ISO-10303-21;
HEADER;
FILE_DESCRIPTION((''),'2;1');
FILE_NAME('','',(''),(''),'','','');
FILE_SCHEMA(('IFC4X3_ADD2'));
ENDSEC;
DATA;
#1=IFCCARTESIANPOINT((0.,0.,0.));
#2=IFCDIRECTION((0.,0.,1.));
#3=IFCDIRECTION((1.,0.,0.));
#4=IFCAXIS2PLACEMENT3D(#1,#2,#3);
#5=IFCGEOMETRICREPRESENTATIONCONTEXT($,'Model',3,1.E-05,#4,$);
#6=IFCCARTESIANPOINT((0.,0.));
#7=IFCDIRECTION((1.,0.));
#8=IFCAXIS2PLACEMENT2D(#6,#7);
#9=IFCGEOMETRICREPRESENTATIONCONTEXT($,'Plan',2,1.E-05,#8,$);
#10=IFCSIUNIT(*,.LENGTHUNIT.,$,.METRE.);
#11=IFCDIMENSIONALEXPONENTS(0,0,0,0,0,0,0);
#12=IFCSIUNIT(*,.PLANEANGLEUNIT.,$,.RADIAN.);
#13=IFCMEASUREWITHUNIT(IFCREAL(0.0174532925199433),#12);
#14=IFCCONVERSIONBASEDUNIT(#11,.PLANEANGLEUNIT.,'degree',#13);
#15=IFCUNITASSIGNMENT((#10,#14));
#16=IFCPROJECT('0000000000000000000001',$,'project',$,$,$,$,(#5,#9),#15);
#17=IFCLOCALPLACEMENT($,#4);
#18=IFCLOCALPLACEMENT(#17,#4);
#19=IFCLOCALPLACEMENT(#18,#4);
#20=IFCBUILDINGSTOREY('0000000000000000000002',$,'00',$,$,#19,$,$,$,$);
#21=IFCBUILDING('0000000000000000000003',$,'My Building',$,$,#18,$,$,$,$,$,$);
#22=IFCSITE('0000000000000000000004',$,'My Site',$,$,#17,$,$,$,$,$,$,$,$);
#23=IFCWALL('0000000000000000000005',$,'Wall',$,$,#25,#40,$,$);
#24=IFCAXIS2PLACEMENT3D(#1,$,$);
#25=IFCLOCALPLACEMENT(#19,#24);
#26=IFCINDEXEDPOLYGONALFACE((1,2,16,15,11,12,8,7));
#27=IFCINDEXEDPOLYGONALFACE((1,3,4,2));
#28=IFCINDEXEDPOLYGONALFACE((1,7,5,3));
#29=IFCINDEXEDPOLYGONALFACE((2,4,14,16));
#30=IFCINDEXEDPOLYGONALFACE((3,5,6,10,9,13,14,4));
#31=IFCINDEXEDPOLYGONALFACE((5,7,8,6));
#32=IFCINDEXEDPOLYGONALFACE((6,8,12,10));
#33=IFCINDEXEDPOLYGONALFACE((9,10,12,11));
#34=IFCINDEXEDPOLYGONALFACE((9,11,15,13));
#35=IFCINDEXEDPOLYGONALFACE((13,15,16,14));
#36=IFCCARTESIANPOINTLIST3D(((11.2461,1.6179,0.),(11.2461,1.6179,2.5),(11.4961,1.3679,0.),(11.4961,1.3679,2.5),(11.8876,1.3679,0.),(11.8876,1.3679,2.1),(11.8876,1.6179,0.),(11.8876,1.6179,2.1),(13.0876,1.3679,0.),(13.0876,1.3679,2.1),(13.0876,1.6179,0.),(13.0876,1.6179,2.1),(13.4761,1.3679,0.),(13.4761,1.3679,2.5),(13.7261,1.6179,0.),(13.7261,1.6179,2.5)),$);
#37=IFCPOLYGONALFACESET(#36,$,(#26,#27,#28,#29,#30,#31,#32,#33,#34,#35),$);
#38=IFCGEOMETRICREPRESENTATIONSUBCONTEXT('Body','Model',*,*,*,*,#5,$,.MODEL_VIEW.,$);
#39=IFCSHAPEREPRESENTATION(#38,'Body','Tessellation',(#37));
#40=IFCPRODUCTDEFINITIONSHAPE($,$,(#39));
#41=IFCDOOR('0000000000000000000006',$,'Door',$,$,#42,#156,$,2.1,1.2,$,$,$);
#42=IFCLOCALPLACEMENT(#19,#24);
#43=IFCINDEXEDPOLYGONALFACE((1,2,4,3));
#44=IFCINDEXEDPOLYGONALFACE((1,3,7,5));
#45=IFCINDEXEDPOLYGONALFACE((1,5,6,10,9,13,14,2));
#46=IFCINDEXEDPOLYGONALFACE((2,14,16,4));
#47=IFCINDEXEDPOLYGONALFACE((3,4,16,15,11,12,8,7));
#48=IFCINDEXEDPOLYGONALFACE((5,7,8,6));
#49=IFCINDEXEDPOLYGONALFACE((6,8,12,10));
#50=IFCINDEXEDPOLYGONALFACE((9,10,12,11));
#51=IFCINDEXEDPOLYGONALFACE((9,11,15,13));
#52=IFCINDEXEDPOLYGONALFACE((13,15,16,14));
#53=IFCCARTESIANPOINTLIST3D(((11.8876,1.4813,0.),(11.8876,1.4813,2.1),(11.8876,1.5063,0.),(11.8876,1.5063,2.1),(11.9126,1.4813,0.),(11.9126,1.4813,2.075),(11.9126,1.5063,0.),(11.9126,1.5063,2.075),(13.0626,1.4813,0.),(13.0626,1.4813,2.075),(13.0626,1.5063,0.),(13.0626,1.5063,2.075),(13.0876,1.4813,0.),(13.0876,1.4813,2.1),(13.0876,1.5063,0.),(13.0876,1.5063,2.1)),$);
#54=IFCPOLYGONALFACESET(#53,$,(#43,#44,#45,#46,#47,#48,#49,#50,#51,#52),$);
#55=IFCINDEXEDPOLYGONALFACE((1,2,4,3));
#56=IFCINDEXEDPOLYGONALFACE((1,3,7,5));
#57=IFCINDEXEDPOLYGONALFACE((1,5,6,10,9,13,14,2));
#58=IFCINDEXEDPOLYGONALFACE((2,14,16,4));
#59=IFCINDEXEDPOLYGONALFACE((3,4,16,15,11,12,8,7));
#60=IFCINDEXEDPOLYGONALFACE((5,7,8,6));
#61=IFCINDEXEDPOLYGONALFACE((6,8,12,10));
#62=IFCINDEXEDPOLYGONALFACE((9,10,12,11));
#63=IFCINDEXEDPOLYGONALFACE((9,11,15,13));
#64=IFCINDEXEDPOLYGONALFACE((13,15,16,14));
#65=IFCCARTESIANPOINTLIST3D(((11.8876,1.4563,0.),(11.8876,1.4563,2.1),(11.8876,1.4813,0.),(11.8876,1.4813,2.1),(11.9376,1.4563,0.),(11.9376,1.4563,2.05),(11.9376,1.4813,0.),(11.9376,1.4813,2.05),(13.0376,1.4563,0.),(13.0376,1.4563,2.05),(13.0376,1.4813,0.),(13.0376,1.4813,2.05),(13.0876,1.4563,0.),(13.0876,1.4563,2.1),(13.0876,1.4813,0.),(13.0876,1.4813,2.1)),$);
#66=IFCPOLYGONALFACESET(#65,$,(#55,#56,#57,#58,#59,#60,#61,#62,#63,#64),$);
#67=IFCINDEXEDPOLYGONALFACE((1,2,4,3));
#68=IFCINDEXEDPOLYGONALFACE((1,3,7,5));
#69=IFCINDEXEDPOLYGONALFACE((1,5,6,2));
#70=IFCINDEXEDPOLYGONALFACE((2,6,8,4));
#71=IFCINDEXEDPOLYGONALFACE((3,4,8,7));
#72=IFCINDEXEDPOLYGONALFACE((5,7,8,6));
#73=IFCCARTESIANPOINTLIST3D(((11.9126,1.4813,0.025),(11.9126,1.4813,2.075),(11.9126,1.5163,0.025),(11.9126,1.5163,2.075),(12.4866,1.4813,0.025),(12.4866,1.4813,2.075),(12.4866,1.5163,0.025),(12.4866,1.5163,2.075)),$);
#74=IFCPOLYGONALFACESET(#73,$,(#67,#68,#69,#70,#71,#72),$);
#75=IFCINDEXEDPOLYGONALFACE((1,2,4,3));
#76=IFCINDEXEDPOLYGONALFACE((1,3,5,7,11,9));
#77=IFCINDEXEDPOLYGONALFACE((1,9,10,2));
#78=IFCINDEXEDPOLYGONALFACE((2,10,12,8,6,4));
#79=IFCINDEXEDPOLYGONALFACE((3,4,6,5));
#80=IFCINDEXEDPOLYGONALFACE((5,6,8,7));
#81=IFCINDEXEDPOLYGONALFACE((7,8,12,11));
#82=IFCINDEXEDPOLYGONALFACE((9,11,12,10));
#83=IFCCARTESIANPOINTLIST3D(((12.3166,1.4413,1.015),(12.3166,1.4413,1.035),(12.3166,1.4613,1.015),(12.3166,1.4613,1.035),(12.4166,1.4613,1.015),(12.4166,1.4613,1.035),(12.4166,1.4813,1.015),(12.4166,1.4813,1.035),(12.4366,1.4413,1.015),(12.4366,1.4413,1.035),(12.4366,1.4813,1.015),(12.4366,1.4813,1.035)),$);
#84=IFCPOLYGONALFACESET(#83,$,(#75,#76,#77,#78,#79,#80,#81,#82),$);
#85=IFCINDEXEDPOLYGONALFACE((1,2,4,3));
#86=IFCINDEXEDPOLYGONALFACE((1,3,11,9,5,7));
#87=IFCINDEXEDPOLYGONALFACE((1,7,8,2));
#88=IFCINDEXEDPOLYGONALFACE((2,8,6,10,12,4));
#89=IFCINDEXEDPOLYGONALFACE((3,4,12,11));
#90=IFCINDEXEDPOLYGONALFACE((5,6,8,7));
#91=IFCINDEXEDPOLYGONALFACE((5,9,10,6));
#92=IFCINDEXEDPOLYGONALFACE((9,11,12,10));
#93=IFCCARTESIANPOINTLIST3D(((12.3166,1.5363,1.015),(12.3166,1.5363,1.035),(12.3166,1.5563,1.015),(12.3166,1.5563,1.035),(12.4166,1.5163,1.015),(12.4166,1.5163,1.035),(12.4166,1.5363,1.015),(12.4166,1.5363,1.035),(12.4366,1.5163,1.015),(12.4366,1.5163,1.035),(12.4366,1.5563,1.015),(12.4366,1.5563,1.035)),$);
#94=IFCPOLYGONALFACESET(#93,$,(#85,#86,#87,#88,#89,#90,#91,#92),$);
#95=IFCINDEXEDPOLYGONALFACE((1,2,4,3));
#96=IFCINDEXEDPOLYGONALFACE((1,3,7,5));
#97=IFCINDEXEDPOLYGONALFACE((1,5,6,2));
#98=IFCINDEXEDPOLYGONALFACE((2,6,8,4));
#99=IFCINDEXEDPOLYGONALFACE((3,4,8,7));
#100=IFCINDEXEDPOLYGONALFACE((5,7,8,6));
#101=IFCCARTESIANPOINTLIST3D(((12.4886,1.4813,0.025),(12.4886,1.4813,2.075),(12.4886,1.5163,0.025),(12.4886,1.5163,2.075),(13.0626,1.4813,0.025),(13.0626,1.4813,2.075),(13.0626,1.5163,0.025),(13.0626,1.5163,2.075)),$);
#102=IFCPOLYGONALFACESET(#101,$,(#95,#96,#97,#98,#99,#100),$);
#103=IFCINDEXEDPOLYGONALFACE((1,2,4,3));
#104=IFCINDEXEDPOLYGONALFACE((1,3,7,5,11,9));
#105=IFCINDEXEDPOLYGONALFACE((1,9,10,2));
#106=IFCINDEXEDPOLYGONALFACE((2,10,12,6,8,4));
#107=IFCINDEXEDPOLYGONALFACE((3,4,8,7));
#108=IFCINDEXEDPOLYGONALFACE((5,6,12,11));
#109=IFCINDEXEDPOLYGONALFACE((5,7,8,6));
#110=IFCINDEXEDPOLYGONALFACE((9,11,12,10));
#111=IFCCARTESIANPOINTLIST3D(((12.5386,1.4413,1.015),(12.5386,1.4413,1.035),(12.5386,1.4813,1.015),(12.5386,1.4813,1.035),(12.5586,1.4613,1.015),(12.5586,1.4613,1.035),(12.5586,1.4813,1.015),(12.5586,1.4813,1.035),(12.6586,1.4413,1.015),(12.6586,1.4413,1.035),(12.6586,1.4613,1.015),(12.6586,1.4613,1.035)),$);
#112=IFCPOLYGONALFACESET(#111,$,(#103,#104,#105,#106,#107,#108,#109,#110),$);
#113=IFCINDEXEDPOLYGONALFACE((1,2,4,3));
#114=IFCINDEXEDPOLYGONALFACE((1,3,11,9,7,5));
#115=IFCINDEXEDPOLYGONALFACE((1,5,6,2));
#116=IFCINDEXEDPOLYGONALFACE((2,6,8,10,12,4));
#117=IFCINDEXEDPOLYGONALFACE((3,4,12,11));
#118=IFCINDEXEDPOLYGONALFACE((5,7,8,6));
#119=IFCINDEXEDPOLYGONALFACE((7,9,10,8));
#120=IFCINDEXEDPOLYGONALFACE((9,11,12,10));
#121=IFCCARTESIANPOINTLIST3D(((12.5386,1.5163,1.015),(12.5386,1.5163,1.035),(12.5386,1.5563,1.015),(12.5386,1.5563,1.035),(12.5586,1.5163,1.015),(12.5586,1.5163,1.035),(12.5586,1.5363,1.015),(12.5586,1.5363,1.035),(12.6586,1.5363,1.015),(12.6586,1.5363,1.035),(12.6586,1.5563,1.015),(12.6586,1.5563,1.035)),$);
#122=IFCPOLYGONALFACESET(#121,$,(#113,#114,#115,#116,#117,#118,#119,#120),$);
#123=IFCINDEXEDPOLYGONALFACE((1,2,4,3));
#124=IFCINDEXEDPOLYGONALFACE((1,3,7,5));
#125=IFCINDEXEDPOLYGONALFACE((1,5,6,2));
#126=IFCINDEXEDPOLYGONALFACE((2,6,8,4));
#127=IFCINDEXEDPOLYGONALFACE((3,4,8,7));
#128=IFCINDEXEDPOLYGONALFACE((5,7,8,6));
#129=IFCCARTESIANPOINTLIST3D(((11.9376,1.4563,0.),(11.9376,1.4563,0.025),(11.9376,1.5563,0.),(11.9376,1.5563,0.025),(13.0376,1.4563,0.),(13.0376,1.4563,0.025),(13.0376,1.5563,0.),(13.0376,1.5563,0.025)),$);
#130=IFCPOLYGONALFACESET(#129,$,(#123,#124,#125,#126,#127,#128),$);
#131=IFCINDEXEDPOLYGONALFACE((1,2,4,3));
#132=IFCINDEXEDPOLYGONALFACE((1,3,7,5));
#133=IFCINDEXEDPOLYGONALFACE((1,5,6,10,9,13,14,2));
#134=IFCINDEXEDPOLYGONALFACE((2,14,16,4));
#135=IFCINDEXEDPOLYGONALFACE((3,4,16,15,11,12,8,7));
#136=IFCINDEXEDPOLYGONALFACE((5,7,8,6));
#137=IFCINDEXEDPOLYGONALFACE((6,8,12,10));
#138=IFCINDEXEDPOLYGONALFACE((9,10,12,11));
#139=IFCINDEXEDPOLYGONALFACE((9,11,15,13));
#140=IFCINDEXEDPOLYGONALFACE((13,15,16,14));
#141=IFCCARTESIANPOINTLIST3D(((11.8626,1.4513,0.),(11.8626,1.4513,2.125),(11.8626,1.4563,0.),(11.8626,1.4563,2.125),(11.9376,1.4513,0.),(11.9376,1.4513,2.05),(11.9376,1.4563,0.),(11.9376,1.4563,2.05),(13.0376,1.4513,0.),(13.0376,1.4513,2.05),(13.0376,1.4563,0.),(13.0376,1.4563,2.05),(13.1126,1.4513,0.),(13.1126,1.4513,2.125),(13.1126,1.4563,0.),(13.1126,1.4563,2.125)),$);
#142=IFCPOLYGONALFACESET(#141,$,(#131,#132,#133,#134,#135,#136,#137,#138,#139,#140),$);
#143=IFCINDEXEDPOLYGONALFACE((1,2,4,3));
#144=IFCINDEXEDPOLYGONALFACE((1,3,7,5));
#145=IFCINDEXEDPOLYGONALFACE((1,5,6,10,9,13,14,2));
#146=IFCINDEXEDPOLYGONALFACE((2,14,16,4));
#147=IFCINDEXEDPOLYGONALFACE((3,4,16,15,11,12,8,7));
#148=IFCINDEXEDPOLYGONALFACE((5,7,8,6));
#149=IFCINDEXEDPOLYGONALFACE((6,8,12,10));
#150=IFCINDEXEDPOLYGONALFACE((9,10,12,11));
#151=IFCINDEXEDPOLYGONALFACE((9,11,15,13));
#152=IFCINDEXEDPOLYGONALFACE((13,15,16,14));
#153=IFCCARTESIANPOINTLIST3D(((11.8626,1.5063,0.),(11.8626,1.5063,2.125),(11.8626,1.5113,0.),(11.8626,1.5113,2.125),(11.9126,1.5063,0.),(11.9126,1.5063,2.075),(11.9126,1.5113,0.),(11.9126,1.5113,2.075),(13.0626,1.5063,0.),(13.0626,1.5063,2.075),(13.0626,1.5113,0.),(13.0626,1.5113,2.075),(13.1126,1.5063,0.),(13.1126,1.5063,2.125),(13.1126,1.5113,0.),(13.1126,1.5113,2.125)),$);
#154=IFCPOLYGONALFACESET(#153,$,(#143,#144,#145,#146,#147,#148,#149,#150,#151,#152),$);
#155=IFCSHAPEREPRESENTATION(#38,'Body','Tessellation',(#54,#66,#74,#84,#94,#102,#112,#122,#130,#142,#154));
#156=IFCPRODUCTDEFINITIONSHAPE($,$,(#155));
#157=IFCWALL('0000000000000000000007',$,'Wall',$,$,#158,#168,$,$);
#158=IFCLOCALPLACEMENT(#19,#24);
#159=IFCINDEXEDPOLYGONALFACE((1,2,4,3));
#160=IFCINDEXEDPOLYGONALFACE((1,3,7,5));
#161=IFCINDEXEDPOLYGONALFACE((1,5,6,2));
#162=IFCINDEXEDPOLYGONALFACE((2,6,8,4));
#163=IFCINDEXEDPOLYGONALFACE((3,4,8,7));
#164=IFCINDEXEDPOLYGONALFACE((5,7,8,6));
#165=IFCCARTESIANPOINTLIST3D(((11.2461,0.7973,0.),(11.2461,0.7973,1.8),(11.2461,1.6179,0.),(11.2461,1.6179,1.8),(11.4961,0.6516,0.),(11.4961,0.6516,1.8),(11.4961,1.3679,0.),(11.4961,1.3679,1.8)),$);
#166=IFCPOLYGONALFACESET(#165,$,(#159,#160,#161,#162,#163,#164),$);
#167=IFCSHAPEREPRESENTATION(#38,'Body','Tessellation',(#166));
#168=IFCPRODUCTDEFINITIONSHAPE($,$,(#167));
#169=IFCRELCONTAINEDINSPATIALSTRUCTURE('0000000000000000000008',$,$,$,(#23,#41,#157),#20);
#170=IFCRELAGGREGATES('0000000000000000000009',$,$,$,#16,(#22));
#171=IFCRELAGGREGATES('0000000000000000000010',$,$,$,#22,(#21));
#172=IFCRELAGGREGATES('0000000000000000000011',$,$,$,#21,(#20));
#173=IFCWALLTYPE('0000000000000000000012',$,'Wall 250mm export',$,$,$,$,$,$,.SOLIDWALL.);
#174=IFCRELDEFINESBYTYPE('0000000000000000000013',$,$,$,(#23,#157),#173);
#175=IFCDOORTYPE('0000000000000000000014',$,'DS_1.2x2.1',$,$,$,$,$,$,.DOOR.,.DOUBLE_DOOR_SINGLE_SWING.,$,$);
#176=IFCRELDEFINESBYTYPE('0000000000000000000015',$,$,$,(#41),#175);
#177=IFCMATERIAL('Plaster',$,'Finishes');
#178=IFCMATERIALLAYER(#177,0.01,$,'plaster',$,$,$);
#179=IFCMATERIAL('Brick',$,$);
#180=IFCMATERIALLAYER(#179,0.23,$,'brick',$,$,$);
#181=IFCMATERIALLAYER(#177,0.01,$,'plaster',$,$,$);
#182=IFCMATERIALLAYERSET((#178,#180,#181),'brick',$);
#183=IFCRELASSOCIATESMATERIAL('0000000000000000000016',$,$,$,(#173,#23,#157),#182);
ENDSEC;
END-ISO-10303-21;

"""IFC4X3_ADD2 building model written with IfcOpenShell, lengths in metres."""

from ifc_helpers import new_model, entity, si_unit, converted_unit, frame, origin_with_axes, origin_2d_with_axis, place, context, subcontext, project, spatial, line, indexed_curve, outline, extrude, shape, source, transform, mapped, material, layer, layer_set, layer_usage, type_object, type_shapes, element, fill, save


model = new_model("IFC4X3_ADD2")

# Units and contexts
model_context = context("Model", 3, precision=1e-05, world=origin_with_axes())
plan_context = context("Plan", 2, precision=1e-05, world=origin_2d_with_axis())
body_context_1 = subcontext(model_context, "Body", "Model", "MODEL_VIEW")
body_context_2 = subcontext(plan_context, "Body", "Plan", "PLAN_VIEW")
ifc_project = project(units=[si_unit("LENGTHUNIT", "METRE"), converted_unit("PLANEANGLEUNIT", "degree", entity("IfcReal", 0.0174532925199433), si_unit("PLANEANGLEUNIT", "RADIAN"), dimensions=[0, 0, 0, 0, 0, 0, 0])], contexts=[model_context, plan_context])

# Site, building, storey
site_placement = place(None, origin_with_axes())
site = spatial("IfcSite", under=ifc_project, at=site_placement, Name="My Site")
building_placement = place(site_placement, origin_with_axes())
building = spatial("IfcBuilding", under=site, at=building_placement, Name="My Building")
storey_placement = place(building_placement, origin_with_axes())
storey = spatial("IfcBuildingStorey", under=building, at=storey_placement, Name="00")

# Shared definitions
ifc_material_1 = material(Name="Plaster", Category="Finishes")
ifc_layer_1 = layer(ifc_material_1, 0.01, Name="plaster")
ifc_material_2 = material(Name="Brick")
ifc_layer_2 = layer(ifc_material_2, 0.23, Name="brick")
ifc_layer_3 = layer(ifc_material_1, 0.01, Name="plaster")
ifc_layer_set_1 = layer_set([ifc_layer_1, ifc_layer_2, ifc_layer_3], Name="brick")
wall_type_1 = type_object("IfcWallType", Name="Wall 250mm export", PredefinedType="SOLIDWALL", material=ifc_layer_set_1)

# Wall, opening, door
ifc_layer_usage_1 = layer_usage(ifc_layer_set_1, "AXIS2", "POSITIVE", 0.0)
wall_1_placement = place(storey_placement, frame((11.4961, 1.3679, 0.0), z_axis=(0.0, 0.0, 1.0), x_axis=(1.0, 0.0, 0.0)))
wall_1 = element("IfcWall", 1, at=wall_1_placement, inside=storey, type_object=wall_type_1, material=ifc_layer_usage_1, Name="Wall", context=body_context_1, shape_type="SweptSolid", body=[
    extrude(outline(indexed_curve([(0.0, 0.0), (-0.25, 0.25), (2.23, 0.25), (1.98, 0.0)], segments=[line(1, 2, 3, 4, 1)])), origin_with_axes(), (0.0, 0.0, 1.0), 2.5),
])
shared_shape_1 = source(origin_with_axes(), body_context_1, "Body", "SweptSolid", [
    extrude(outline(indexed_curve([(0.0, 0.0), (1.2, 0.0), (1.2, 2.1), (0.0, 2.1)], segments=[line(1, 2, 3, 4, 1)])), frame((0.0, -0.6, 0.0), z_axis=(0.0, -1.0, 0.0), x_axis=(1.0, 0.0, 0.0)), (0.0, 0.0, -1.0), 1.2),
])
opening_1_placement = place(wall_1_placement, frame((0.3915, 0.0885, 0.0), z_axis=(0.0, 0.0, 1.0), x_axis=(1.0, 0.0, 0.0)))
opening_1 = element("IfcOpeningElement", 2, at=opening_1_placement, cuts=wall_1, PredefinedType="OPENING", context=body_context_1, shape_type="MappedRepresentation", body=[
    mapped(shared_shape_1, transform((0.0, 0.0, 0.0), x_axis=(1.0, 0.0, 0.0), y_axis=(0.0, 1.0, 0.0), z_axis=(0.0, 0.0, 1.0), scale=1.0)),
])
door_type_1 = type_object("IfcDoorType", Name="DS_1.2x2.1", OperationType="DOUBLE_DOOR_SINGLE_SWING", PredefinedType="DOOR")
shared_shape_2 = source(origin_with_axes(), body_context_1, "Body", "SweptSolid", [
    extrude(outline(indexed_curve([(0.0, 0.0), (0.0, 2.1), (1.2, 2.1), (1.2, 0.0), (1.175, 0.0), (1.175, 2.075), (0.025, 2.075), (0.025, 0.0)], segments=[line(1, 2, 3, 4, 5, 6, 7, 8, 1)])), frame((0.0, 0.025, 0.0), z_axis=(0.0, -1.0, 0.0), x_axis=(1.0, 0.0, 0.0)), (0.0, 0.0, -1.0), 0.025),
    extrude(outline(indexed_curve([(0.0, 0.0), (0.0, 2.1), (1.2, 2.1), (1.2, 0.0), (1.15, 0.0), (1.15, 2.05), (0.05, 2.05), (0.05, 0.0)], segments=[line(1, 2, 3, 4, 5, 6, 7, 8, 1)])), frame((0.0, 0.0, 0.0), z_axis=(0.0, -1.0, 0.0), x_axis=(1.0, 0.0, 0.0)), (0.0, 0.0, -1.0), 0.025),
    extrude(outline(indexed_curve([(0.0, 0.0), (0.574, 0.0), (0.574, 0.035), (0.0, 0.035)], segments=[line(1, 2, 3, 4, 1)])), frame((0.025, 0.025, 0.025), z_axis=(0.0, 0.0, 1.0), x_axis=(1.0, 0.0, 0.0)), (0.0, 0.0, 1.0), 2.05),
    extrude(outline(indexed_curve([(0.0, 0.0), (0.0, -0.04), (-0.12, -0.04), (-0.12, -0.02), (-0.02, -0.02), (-0.02, 0.0)], segments=[line(1, 2, 3, 4, 5, 6, 1)])), frame((0.549, 0.025, 1.015), z_axis=(0.0, 0.0, 1.0), x_axis=(1.0, 0.0, 0.0)), (0.0, 0.0, 1.0), 0.02),
    extrude(outline(indexed_curve([(0.0, 0.0), (0.0, 0.04), (-0.12, 0.04), (-0.12, 0.02), (-0.02, 0.02), (-0.02, 0.0)], segments=[line(1, 2, 3, 4, 5, 6, 1)])), frame((0.549, 0.06, 1.015), z_axis=(0.0, 0.0, 1.0), x_axis=(1.0, 0.0, 0.0)), (0.0, 0.0, 1.0), 0.02),
    extrude(outline(indexed_curve([(0.0, 0.0), (-0.574, 0.0), (-0.574, 0.035), (0.0, 0.035)], segments=[line(1, 2, 3, 4, 1)])), frame((1.175, 0.025, 0.025), z_axis=(0.0, 0.0, 1.0), x_axis=(1.0, 0.0, 0.0)), (0.0, 0.0, 1.0), 2.05),
    extrude(outline(indexed_curve([(0.0, 0.0), (0.0, -0.04), (0.12, -0.04), (0.12, -0.02), (0.02, -0.02), (0.02, 0.0)], segments=[line(1, 2, 3, 4, 5, 6, 1)])), frame((0.651, 0.025, 1.015), z_axis=(0.0, 0.0, 1.0), x_axis=(1.0, 0.0, 0.0)), (0.0, 0.0, 1.0), 0.02),
    extrude(outline(indexed_curve([(0.0, 0.0), (0.0, 0.04), (0.12, 0.04), (0.12, 0.02), (0.02, 0.02), (0.02, 0.0)], segments=[line(1, 2, 3, 4, 5, 6, 1)])), frame((0.651, 0.06, 1.015), z_axis=(0.0, 0.0, 1.0), x_axis=(1.0, 0.0, 0.0)), (0.0, 0.0, 1.0), 0.02),
    extrude(outline(indexed_curve([(0.0, 0.0), (1.1, 0.0), (1.1, 0.1), (0.0, 0.1)], segments=[line(1, 2, 3, 4, 1)])), frame((0.05, 0.0, 0.0), z_axis=(0.0, 0.0, 1.0), x_axis=(1.0, 0.0, 0.0)), (0.0, 0.0, 1.0), 0.025),
    extrude(outline(indexed_curve([(0.0, 0.0), (0.0, 2.125), (1.25, 2.125), (1.25, 0.0), (1.175, 0.0), (1.175, 2.05), (0.075, 2.05), (0.075, 0.0)], segments=[line(1, 2, 3, 4, 5, 6, 7, 8, 1)])), frame((-0.025, -0.005, 0.0), z_axis=(0.0, -1.0, 0.0), x_axis=(1.0, 0.0, 0.0)), (0.0, 0.0, -1.0), 0.005),
    extrude(outline(indexed_curve([(0.0, 0.0), (0.0, 2.125), (1.25, 2.125), (1.25, 0.0), (1.2, 0.0), (1.2, 2.075), (0.05, 2.075), (0.05, 0.0)], segments=[line(1, 2, 3, 4, 5, 6, 7, 8, 1)])), frame((-0.025, 0.05, 0.0), z_axis=(0.0, -1.0, 0.0), x_axis=(1.0, 0.0, 0.0)), (0.0, 0.0, -1.0), 0.005),
])
shared_shape_3 = source(origin_with_axes(), body_context_2, "Body", "Curve2D", [
    entity("IfcIndexedPolyCurve", entity("IfcCartesianPointList2D", [[0.0, 0.0], [0.0, 0.05], [0.025, 0.05], [0.025, 0.025], [0.05, 0.025], [0.05, 0.0]]), [entity("IfcLineIndex", [1, 2, 3, 4, 5, 6, 1])]),
    entity("IfcIndexedPolyCurve", entity("IfcCartesianPointList2D", [[1.2, 0.0], [1.2, 0.05], [1.175, 0.05], [1.175, 0.025], [1.15, 0.025], [1.15, 0.0]]), [entity("IfcLineIndex", [1, 2, 3, 4, 5, 6, 1])]),
    entity("IfcTrimmedCurve", entity("IfcEllipse", entity("IfcAxis2Placement2D", entity("IfcCartesianPoint", [0.06, 0.05]), entity("IfcDirection", [1.0, 0.0])), 0.54, 0.575), [entity("IfcCartesianPoint", [0.6, 0.05])], [entity("IfcCartesianPoint", [0.06, 0.625])], True, "CARTESIAN"),
    entity("IfcIndexedPolyCurve", entity("IfcCartesianPointList2D", [[0.025, 0.05], [0.06, 0.05], [0.06, 0.625], [0.025, 0.625]]), [entity("IfcLineIndex", [1, 2, 3, 4, 1])]),
    entity("IfcTrimmedCurve", entity("IfcEllipse", entity("IfcAxis2Placement2D", entity("IfcCartesianPoint", [1.14, 0.05]), entity("IfcDirection", [1.0, 0.0])), 0.54, 0.575), [entity("IfcCartesianPoint", [1.14, 0.625])], [entity("IfcCartesianPoint", [0.6, 0.05])], True, "CARTESIAN"),
    entity("IfcIndexedPolyCurve", entity("IfcCartesianPointList2D", [[1.175, 0.05], [1.14, 0.05], [1.14, 0.625], [1.175, 0.625]]), [entity("IfcLineIndex", [1, 2, 3, 4, 1])]),
])
type_shapes(door_type_1, [shared_shape_2, shared_shape_3])
door_1_placement = place(opening_1_placement, origin_with_axes())
door_1 = element("IfcDoor", 3, at=door_1_placement, inside=storey, type_object=door_type_1, Name="Door", OverallHeight=2.1, OverallWidth=1.2, shapes=[
    shape(body_context_1, "Body", "MappedRepresentation", [mapped(shared_shape_2, transform((0.0, 0.0, 0.0), x_axis=(1.0, 0.0, 0.0), y_axis=(0.0, 1.0, 0.0), z_axis=(0.0, 0.0, 1.0), scale=1.0))]),
    shape(body_context_2, "Body", "MappedRepresentation", [mapped(shared_shape_3, transform((0.0, 0.0, 0.0), x_axis=(1.0, 0.0, 0.0), y_axis=(0.0, 1.0, 0.0), z_axis=(0.0, 0.0, 1.0), scale=1.0))]),
])
fill(opening_1, door_1)

# Wall
ifc_layer_usage_2 = layer_usage(ifc_layer_set_1, "AXIS2", "POSITIVE", 0.0)
wall_2_placement = place(storey_placement, frame((11.4961, 0.6516, 0.0), z_axis=(0.0, 0.0, 1.0), x_axis=(0.000001, 1.0, 0.0)))
element("IfcWall", 4, at=wall_2_placement, inside=storey, type_object=wall_type_1, material=ifc_layer_usage_2, Name="Wall", context=body_context_1, shape_type="SweptSolid", body=[
    extrude(outline(indexed_curve([(0.0, 0.0), (0.1458, 0.25), (0.9663, 0.25), (0.7163, 0.0)], segments=[line(1, 2, 3, 4, 1)])), origin_with_axes(), (0.0, 0.0, 1.0), 1.8),
])

save(model, "model.ifc")
